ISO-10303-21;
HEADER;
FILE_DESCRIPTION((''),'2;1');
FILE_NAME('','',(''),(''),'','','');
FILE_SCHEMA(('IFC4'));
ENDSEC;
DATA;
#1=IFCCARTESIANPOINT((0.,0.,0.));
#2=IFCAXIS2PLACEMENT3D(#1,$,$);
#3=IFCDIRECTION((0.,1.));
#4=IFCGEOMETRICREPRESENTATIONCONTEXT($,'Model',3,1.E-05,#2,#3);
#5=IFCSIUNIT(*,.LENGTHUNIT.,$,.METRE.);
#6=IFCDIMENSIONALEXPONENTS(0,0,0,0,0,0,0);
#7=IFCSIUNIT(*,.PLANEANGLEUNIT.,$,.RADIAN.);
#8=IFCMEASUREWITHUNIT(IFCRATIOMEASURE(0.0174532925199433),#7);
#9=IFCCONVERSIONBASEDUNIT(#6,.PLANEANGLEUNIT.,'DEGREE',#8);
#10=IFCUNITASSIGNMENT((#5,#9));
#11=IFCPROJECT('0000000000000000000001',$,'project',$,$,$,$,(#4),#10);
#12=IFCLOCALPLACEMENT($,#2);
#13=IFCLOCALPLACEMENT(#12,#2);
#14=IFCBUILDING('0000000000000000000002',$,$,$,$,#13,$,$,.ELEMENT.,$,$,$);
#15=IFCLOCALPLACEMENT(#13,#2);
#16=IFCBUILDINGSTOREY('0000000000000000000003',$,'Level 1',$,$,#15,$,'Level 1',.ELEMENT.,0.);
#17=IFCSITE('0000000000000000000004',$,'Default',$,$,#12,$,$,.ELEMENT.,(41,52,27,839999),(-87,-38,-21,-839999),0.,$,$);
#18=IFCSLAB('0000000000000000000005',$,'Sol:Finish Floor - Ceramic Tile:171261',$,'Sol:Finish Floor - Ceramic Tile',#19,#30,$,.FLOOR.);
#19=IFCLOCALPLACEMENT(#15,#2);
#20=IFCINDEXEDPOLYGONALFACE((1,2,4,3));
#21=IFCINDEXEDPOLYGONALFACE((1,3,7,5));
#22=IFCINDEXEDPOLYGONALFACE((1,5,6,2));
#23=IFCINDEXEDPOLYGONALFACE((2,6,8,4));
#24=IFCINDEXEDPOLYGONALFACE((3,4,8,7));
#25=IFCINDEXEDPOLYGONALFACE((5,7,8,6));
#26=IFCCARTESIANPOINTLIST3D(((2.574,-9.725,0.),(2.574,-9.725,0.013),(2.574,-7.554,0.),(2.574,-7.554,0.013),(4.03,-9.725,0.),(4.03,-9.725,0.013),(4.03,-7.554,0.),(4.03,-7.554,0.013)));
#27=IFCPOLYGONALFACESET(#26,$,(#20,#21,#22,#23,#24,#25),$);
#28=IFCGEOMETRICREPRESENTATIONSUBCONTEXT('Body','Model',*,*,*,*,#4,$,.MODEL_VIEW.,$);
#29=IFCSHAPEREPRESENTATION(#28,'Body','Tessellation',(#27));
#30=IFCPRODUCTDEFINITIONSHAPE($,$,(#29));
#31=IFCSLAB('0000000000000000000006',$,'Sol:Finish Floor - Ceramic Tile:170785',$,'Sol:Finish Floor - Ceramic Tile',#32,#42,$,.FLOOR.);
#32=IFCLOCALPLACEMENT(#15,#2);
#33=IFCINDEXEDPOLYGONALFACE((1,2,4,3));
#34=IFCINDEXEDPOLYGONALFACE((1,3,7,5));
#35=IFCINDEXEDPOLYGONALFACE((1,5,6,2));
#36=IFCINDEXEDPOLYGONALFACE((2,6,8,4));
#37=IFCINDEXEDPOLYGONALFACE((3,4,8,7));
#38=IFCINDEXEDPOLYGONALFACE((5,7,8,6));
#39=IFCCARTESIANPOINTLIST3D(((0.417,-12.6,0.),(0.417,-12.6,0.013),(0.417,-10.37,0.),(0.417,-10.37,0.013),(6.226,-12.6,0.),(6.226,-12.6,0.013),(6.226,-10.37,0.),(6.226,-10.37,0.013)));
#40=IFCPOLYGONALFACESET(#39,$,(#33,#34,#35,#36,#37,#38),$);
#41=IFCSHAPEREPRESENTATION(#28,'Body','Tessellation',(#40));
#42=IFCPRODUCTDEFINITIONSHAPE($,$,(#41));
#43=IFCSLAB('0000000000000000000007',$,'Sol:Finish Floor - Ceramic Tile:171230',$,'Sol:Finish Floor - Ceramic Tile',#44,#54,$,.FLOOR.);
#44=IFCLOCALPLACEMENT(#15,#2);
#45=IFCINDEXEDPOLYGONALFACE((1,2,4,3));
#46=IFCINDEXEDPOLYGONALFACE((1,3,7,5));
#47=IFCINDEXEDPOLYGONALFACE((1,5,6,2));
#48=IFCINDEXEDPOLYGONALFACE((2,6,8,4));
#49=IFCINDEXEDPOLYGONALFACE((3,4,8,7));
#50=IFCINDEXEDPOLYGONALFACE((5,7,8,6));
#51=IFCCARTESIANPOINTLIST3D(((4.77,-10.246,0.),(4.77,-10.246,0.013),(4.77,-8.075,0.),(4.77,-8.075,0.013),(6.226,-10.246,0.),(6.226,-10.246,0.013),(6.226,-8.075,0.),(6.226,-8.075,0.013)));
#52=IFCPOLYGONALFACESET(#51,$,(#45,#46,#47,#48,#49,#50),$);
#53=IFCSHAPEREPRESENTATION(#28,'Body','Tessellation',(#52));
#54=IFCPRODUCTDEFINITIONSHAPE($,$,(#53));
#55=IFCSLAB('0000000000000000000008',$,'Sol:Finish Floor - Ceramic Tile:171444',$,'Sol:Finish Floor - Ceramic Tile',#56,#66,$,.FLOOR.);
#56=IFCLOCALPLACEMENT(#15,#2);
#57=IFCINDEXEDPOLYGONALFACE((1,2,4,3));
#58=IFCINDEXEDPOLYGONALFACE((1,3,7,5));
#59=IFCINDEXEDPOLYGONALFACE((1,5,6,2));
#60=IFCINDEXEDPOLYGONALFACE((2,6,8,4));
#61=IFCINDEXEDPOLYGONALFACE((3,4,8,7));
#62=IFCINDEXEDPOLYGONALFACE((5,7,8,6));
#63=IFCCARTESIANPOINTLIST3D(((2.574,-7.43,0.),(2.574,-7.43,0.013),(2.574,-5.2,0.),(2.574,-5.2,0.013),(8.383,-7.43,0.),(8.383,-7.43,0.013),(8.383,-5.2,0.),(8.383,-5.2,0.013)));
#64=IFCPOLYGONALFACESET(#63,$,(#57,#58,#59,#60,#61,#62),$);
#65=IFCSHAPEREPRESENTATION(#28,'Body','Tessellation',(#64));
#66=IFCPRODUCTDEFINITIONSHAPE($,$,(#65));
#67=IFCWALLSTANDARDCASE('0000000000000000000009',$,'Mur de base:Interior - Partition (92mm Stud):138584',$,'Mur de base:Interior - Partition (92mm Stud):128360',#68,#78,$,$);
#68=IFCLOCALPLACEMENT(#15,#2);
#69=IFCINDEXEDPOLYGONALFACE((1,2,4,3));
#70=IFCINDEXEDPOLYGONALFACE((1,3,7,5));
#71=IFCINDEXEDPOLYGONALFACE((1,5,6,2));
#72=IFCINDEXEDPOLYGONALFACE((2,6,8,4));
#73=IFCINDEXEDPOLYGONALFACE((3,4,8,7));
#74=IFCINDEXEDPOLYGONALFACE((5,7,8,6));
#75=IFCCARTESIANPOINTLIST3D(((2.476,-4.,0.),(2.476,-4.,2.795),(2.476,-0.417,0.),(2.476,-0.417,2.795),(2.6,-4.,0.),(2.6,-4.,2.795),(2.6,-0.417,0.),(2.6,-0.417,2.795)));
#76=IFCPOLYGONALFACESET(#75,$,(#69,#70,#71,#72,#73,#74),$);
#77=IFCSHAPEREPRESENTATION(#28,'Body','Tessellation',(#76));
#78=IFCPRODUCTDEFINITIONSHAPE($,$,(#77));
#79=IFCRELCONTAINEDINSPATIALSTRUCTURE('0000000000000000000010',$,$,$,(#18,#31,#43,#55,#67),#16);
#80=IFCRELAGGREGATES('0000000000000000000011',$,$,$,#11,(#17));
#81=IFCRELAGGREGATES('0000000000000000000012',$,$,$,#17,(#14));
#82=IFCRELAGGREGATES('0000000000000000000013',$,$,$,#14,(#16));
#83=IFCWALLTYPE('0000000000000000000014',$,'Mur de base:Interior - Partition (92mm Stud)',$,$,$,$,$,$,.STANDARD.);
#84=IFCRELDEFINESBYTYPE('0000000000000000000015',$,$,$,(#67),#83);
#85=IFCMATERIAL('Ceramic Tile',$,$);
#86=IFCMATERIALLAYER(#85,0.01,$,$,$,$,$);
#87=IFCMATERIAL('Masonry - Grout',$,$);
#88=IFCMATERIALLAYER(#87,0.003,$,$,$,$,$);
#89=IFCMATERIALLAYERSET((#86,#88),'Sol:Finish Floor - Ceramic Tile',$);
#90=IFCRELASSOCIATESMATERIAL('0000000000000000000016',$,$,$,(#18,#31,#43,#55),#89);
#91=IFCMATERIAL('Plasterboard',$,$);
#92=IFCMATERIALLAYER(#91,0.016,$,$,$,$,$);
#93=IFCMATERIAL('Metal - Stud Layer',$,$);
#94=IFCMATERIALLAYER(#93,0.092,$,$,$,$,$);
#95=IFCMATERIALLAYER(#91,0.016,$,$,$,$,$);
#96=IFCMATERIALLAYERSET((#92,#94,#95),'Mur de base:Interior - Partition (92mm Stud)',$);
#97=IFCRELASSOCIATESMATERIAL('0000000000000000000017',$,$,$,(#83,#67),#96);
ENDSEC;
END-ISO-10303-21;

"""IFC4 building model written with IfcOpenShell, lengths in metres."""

from ifc_helpers import new_model, entity, si_unit, converted_unit, direction, frame, frame_2d, origin, place, context, subcontext, project, spatial, rectangle, extrude, material, layer, layer_set, layer_usage, type_object, element, save


model = new_model("IFC4")

# Units and contexts
model_context = context("Model", 3, precision=1e-05, world=origin(), true_north=direction((0.0, 1.0)))
body_context = subcontext(model_context, "Body", "Model", "MODEL_VIEW")
ifc_project = project(units=[si_unit("LENGTHUNIT", "METRE"), converted_unit("PLANEANGLEUNIT", "DEGREE", entity("IfcRatioMeasure", 0.0174532925199433), si_unit("PLANEANGLEUNIT", "RADIAN"), dimensions=[0, 0, 0, 0, 0, 0, 0])], contexts=[model_context])

# Site, building, storey
site_placement = place(None, origin())
site = spatial("IfcSite", under=ifc_project, at=site_placement, Name="Default", CompositionType="ELEMENT", RefLatitude=(41, 52, 27, 839999), RefLongitude=(-87, -38, -21, -839999), RefElevation=0.0)
building_placement = place(site_placement, origin())
building = spatial("IfcBuilding", under=site, at=building_placement, CompositionType="ELEMENT")
storey_placement = place(building_placement, origin())
storey = spatial("IfcBuildingStorey", under=building, at=storey_placement, Name="Level 1", LongName="Level 1", CompositionType="ELEMENT", Elevation=0.0)

# Slabs
ifc_material_1 = material(Name="Ceramic Tile")
ifc_layer_1 = layer(ifc_material_1, 0.01)
ifc_material_2 = material(Name="Masonry - Grout")
ifc_layer_2 = layer(ifc_material_2, 0.003)
ifc_layer_set_1 = layer_set([ifc_layer_1, ifc_layer_2], Name="Sol:Finish Floor - Ceramic Tile")
ifc_layer_usage_1 = layer_usage(ifc_layer_set_1, "AXIS3", "POSITIVE", 0.0)
slab_1_placement = place(storey_placement, origin())
element("IfcSlab", 1, at=slab_1_placement, inside=storey, material=ifc_layer_usage_1, Name="Sol:Finish Floor - Ceramic Tile:171261", ObjectType="Sol:Finish Floor - Ceramic Tile", PredefinedType="FLOOR", context=body_context, shape_type="SweptSolid", body=[
    extrude(rectangle(XDim=2.171, YDim=1.456, at=frame_2d((0.0, 0.0), x_axis=(1.0, 0.0))), frame((3.302, -8.6395, 0.013), z_axis=(0.0, 0.0, -1.0), x_axis=(0.0, 1.0, 0.0)), (0.0, 0.0, 1.0), 0.013),
])
ifc_layer_usage_2 = layer_usage(ifc_layer_set_1, "AXIS3", "POSITIVE", 0.0)
slab_2_placement = place(storey_placement, origin())
element("IfcSlab", 2, at=slab_2_placement, inside=storey, material=ifc_layer_usage_2, Name="Sol:Finish Floor - Ceramic Tile:170785", ObjectType="Sol:Finish Floor - Ceramic Tile", PredefinedType="FLOOR", context=body_context, shape_type="SweptSolid", body=[
    extrude(rectangle(XDim=2.23, YDim=5.809, at=frame_2d((0.0, 0.0), x_axis=(1.0, 0.0))), frame((3.3215, -11.485, 0.013), z_axis=(0.0, 0.0, -1.0), x_axis=(0.0, 1.0, 0.0)), (0.0, 0.0, 1.0), 0.013),
])
ifc_layer_usage_3 = layer_usage(ifc_layer_set_1, "AXIS3", "POSITIVE", 0.0)
slab_3_placement = place(storey_placement, origin())
element("IfcSlab", 3, at=slab_3_placement, inside=storey, material=ifc_layer_usage_3, Name="Sol:Finish Floor - Ceramic Tile:171230", ObjectType="Sol:Finish Floor - Ceramic Tile", PredefinedType="FLOOR", context=body_context, shape_type="SweptSolid", body=[
    extrude(rectangle(XDim=2.171, YDim=1.456, at=frame_2d((0.0, 0.0), x_axis=(1.0, 0.0))), frame((5.498, -9.1605, 0.013), z_axis=(0.0, 0.0, -1.0), x_axis=(0.0, 1.0, 0.0)), (0.0, 0.0, 1.0), 0.013),
])
ifc_layer_usage_4 = layer_usage(ifc_layer_set_1, "AXIS3", "POSITIVE", 0.0)
slab_4_placement = place(storey_placement, origin())
element("IfcSlab", 4, at=slab_4_placement, inside=storey, material=ifc_layer_usage_4, Name="Sol:Finish Floor - Ceramic Tile:171444", ObjectType="Sol:Finish Floor - Ceramic Tile", PredefinedType="FLOOR", context=body_context, shape_type="SweptSolid", body=[
    extrude(rectangle(XDim=2.23, YDim=5.809, at=frame_2d((0.0, 0.0), x_axis=(1.0, 0.0))), frame((5.4785, -6.315, 0.013), z_axis=(0.0, 0.0, -1.0), x_axis=(0.0, 1.0, 0.0)), (0.0, 0.0, 1.0), 0.013),
])

# Wall
ifc_material_3 = material(Name="Plasterboard")
ifc_layer_3 = layer(ifc_material_3, 0.016)
ifc_material_4 = material(Name="Metal - Stud Layer")
ifc_layer_4 = layer(ifc_material_4, 0.092)
ifc_layer_5 = layer(ifc_material_3, 0.016)
ifc_layer_set_2 = layer_set([ifc_layer_3, ifc_layer_4, ifc_layer_5], Name="Mur de base:Interior - Partition (92mm Stud)")
ifc_layer_usage_5 = layer_usage(ifc_layer_set_2, "AXIS2", "NEGATIVE", 0.062)
wall_type_1 = type_object("IfcWallType", Name="Mur de base:Interior - Partition (92mm Stud)", PredefinedType="STANDARD", material=ifc_layer_set_2)
wall_1_placement = place(storey_placement, frame((2.538, -0.417, 0.0), z_axis=(0.0, 0.0, 1.0), x_axis=(0.0, -1.0, 0.0)))
element("IfcWallStandardCase", 5, at=wall_1_placement, inside=storey, type_object=wall_type_1, material=ifc_layer_usage_5, Name="Mur de base:Interior - Partition (92mm Stud):138584", ObjectType="Mur de base:Interior - Partition (92mm Stud):128360", context=body_context, shape_type="SweptSolid", body=[
    extrude(rectangle(XDim=3.583, YDim=0.124, at=frame_2d((1.7915, 0.0), x_axis=(-1.0, 0.0))), origin(), (0.0, 0.0, 1.0), 2.795),
])

save(model, "model.ifc")
